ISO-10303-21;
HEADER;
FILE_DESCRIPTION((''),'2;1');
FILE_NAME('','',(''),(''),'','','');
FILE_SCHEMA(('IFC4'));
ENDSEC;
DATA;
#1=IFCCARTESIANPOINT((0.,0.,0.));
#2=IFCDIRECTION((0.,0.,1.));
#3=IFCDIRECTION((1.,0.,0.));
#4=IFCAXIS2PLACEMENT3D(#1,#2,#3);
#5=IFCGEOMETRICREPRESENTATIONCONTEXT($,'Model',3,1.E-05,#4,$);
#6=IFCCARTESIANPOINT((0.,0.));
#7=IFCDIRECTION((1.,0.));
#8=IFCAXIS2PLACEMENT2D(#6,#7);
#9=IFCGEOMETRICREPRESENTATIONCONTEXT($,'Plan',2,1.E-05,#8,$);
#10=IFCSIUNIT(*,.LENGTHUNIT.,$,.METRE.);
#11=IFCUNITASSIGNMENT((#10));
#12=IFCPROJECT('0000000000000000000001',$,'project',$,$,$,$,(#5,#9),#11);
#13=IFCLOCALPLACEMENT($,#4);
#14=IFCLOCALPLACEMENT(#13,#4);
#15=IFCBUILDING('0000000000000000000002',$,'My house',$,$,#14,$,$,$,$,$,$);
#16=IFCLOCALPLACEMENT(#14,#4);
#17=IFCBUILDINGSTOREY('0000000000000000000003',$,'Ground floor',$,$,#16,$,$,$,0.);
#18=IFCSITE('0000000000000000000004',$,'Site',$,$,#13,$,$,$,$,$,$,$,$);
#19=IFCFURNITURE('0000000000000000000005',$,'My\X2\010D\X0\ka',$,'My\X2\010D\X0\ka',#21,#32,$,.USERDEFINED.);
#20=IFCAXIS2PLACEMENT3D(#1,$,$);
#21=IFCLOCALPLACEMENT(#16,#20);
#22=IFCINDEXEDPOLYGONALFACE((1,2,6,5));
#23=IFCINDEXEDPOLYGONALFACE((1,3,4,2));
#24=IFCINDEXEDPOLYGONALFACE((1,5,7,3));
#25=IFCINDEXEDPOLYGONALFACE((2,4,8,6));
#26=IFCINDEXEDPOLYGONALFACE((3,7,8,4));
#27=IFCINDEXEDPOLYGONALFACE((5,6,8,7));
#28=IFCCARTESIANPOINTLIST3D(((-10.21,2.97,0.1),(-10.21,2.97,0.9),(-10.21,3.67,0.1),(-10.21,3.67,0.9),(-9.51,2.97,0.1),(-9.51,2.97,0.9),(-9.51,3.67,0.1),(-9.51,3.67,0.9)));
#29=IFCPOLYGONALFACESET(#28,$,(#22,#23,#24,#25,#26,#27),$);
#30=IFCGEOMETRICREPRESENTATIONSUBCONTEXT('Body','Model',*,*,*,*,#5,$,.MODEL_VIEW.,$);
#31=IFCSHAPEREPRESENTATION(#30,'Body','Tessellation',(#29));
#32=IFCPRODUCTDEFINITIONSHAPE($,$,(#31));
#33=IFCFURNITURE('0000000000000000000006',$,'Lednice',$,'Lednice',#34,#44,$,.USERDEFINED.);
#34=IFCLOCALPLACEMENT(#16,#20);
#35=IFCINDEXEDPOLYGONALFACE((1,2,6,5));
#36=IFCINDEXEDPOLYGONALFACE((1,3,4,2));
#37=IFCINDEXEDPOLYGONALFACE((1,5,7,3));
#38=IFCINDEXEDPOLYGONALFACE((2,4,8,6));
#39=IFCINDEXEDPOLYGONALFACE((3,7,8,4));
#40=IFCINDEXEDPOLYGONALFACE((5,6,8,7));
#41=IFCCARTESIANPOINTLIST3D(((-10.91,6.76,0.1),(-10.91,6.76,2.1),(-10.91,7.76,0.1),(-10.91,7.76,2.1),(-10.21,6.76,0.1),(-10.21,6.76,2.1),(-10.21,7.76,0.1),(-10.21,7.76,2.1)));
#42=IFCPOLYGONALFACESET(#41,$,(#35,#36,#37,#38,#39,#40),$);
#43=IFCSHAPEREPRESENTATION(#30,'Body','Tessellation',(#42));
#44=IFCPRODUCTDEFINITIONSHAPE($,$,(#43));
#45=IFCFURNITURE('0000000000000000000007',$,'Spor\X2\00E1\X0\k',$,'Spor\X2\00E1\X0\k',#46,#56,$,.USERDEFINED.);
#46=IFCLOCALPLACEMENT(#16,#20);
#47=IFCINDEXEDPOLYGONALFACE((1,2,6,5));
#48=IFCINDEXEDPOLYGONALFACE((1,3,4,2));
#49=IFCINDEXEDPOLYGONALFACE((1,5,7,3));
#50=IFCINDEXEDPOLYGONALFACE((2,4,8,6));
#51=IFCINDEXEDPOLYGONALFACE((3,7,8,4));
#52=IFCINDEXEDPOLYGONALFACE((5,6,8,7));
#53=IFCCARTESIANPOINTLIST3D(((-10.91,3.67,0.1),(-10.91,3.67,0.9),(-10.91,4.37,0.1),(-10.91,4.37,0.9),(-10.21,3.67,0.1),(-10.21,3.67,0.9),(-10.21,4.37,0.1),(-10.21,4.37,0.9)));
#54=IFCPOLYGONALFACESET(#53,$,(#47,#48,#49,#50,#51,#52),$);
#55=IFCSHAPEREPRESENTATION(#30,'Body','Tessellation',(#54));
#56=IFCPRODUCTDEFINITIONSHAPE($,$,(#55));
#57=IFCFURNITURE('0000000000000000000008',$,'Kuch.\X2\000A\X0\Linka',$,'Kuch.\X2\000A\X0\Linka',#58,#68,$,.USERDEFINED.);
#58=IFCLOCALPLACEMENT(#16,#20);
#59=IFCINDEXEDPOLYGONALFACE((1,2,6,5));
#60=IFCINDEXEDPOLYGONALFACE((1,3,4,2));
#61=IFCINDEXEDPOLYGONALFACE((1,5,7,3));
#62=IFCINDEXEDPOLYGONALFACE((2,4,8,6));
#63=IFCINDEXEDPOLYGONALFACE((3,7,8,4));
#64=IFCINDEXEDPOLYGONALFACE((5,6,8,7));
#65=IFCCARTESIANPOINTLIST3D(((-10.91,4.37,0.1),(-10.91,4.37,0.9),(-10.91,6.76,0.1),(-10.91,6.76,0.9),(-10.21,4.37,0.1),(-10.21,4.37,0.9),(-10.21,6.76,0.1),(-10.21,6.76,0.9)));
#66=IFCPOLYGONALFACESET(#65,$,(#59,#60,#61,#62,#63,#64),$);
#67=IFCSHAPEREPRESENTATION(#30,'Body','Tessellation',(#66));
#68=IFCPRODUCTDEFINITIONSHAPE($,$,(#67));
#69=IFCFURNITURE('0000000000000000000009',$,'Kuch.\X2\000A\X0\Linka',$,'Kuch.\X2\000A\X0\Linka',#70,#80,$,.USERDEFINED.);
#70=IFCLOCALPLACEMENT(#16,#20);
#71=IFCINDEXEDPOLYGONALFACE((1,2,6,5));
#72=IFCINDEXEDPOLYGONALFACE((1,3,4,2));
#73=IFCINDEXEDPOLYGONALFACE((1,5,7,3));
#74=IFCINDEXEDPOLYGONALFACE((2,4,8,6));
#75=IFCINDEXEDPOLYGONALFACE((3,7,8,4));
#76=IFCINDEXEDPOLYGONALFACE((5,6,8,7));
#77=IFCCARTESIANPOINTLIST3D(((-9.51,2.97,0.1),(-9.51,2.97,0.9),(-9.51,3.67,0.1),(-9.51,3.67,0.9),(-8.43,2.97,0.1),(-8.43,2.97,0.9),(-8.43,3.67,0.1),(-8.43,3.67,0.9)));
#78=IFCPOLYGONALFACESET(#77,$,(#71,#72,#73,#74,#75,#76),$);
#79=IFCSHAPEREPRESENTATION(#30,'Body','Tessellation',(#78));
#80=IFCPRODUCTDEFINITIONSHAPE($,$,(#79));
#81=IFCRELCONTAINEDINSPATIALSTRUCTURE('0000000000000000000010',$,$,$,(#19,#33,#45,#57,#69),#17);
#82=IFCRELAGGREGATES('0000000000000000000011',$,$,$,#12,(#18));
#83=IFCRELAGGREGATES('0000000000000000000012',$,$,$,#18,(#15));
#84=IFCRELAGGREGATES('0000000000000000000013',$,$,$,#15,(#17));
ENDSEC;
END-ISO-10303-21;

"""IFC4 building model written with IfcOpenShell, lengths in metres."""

from ifc_helpers import new_model, entity, si_unit, frame, origin_with_axes, origin_2d_with_axis, place, context, subcontext, project, spatial, indexed_curve, outline, extrude, shape, source, transform, mapped, element, save


model = new_model("IFC4")

# Units and contexts
model_context = context("Model", 3, precision=1e-05, world=origin_with_axes())
plan_context = context("Plan", 2, precision=1e-05, world=origin_2d_with_axis())
body_context_1 = subcontext(model_context, "Body", "Model", "MODEL_VIEW")
body_context_2 = subcontext(plan_context, "Body", "Plan", "PLAN_VIEW")
ifc_project = project(units=[si_unit("LENGTHUNIT", "METRE")], contexts=[model_context, plan_context])

# Site, building, storey
site_placement = place(None, origin_with_axes())
site = spatial("IfcSite", under=ifc_project, at=site_placement, Name="Site")
building_placement = place(site_placement, origin_with_axes())
building = spatial("IfcBuilding", under=site, at=building_placement, Name="My house")
storey_placement = place(building_placement, origin_with_axes())
storey = spatial("IfcBuildingStorey", under=building, at=storey_placement, Name="Ground floor", Elevation=0.0)

# Furniture
shared_shape_1 = source(origin_with_axes(), body_context_1, "Body", "SweptSolid", [
    extrude(outline(indexed_curve([(-0.35, -0.35), (0.35, -0.35), (0.35, 0.35), (-0.35, 0.35)])), None, (0.0, 0.0, 1.0), 0.8),
])
shared_shape_2 = source(origin_with_axes(), body_context_2, "Body", "Curve2D", [
    entity("IfcIndexedPolyCurve", entity("IfcCartesianPointList2D", [[-0.35, -0.35], [0.35, -0.35], [0.35, 0.35], [-0.35, 0.35], [-0.35, -0.35]]), None, False),
])
furniture_1_placement = place(storey_placement, frame((-9.86, 3.32, 0.1), z_axis=(0.0, 0.0, 1.0), x_axis=(1.0, 0.0, 0.0)))
element("IfcFurniture", 1, at=furniture_1_placement, inside=storey, Name="Myčka", ObjectType="Myčka", PredefinedType="USERDEFINED", shapes=[
    shape(body_context_1, "Body", "MappedRepresentation", [mapped(shared_shape_1, transform((0.0, 0.0, 0.0), x_axis=(-1.0, 0.0, 0.0), y_axis=(0.0, 1.0, 0.0), z_axis=(0.0, 0.0, 1.0), scale=1.0))]),
    shape(body_context_2, "Body", "MappedRepresentation", [mapped(shared_shape_2, transform((0.0, 0.0, 0.0), x_axis=(-1.0, 0.0, 0.0), y_axis=(0.0, 1.0, 0.0), z_axis=(0.0, 0.0, 1.0), scale=1.0))]),
])
shared_shape_3 = source(origin_with_axes(), body_context_1, "Body", "SweptSolid", [
    extrude(outline(indexed_curve([(-0.35, -0.5), (0.35, -0.5), (0.35, 0.5), (-0.35, 0.5)])), None, (0.0, 0.0, 1.0), 2.0),
])
shared_shape_4 = source(origin_with_axes(), body_context_2, "Body", "Curve2D", [
    entity("IfcIndexedPolyCurve", entity("IfcCartesianPointList2D", [[-0.35, -0.5], [0.35, -0.5], [0.35, 0.5], [-0.35, 0.5], [-0.35, -0.5]]), None, False),
])
furniture_2_placement = place(storey_placement, frame((-10.56, 7.26, 0.1), z_axis=(0.0, 0.0, 1.0), x_axis=(1.0, 0.0, 0.0)))
element("IfcFurniture", 2, at=furniture_2_placement, inside=storey, Name="Lednice", ObjectType="Lednice", PredefinedType="USERDEFINED", shapes=[
    shape(body_context_1, "Body", "MappedRepresentation", [mapped(shared_shape_3, transform((0.0, 0.0, 0.0), x_axis=(-1.0, 0.0, 0.0), y_axis=(0.0, 1.0, 0.0), z_axis=(0.0, 0.0, 1.0), scale=1.0))]),
    shape(body_context_2, "Body", "MappedRepresentation", [mapped(shared_shape_4, transform((0.0, 0.0, 0.0), x_axis=(-1.0, 0.0, 0.0), y_axis=(0.0, 1.0, 0.0), z_axis=(0.0, 0.0, 1.0), scale=1.0))]),
])
shared_shape_5 = source(origin_with_axes(), body_context_1, "Body", "SweptSolid", [
    extrude(outline(indexed_curve([(-0.35, -0.35), (0.35, -0.35), (0.35, 0.35), (-0.35, 0.35)])), None, (0.0, 0.0, 1.0), 0.8),
])
shared_shape_6 = source(origin_with_axes(), body_context_2, "Body", "Curve2D", [
    entity("IfcIndexedPolyCurve", entity("IfcCartesianPointList2D", [[-0.35, -0.35], [0.35, -0.35], [0.35, 0.35], [-0.35, 0.35], [-0.35, -0.35]]), None, False),
])
furniture_3_placement = place(storey_placement, frame((-10.56, 4.02, 0.1), z_axis=(0.0, 0.0, 1.0), x_axis=(1.0, 0.0, 0.0)))
element("IfcFurniture", 3, at=furniture_3_placement, inside=storey, Name="Sporák", ObjectType="Sporák", PredefinedType="USERDEFINED", shapes=[
    shape(body_context_1, "Body", "MappedRepresentation", [mapped(shared_shape_5, transform((0.0, 0.0, 0.0), x_axis=(-1.0, 0.0, 0.0), y_axis=(0.0, 1.0, 0.0), z_axis=(0.0, 0.0, 1.0), scale=1.0))]),
    shape(body_context_2, "Body", "MappedRepresentation", [mapped(shared_shape_6, transform((0.0, 0.0, 0.0), x_axis=(-1.0, 0.0, 0.0), y_axis=(0.0, 1.0, 0.0), z_axis=(0.0, 0.0, 1.0), scale=1.0))]),
])
shared_shape_7 = source(origin_with_axes(), body_context_1, "Body", "SweptSolid", [
    extrude(outline(indexed_curve([(-0.35, -1.195), (0.35, -1.195), (0.35, 1.195), (-0.35, 1.195)])), None, (0.0, 0.0, 1.0), 0.8),
])
shared_shape_8 = source(origin_with_axes(), body_context_2, "Body", "Curve2D", [
    entity("IfcIndexedPolyCurve", entity("IfcCartesianPointList2D", [[-0.35, -1.195], [0.35, -1.195], [0.35, 1.195], [-0.35, 1.195], [-0.35, -1.195]]), None, False),
])
furniture_4_placement = place(storey_placement, frame((-10.56, 5.565, 0.1), z_axis=(0.0, 0.0, 1.0), x_axis=(1.0, 0.0, 0.0)))
element("IfcFurniture", 4, at=furniture_4_placement, inside=storey, Name="Kuch.\nLinka", ObjectType="Kuch.\nLinka", PredefinedType="USERDEFINED", shapes=[
    shape(body_context_1, "Body", "MappedRepresentation", [mapped(shared_shape_7, transform((0.0, 0.0, 0.0), x_axis=(-1.0, 0.0, 0.0), y_axis=(0.0, 1.0, 0.0), z_axis=(0.0, 0.0, 1.0), scale=1.0))]),
    shape(body_context_2, "Body", "MappedRepresentation", [mapped(shared_shape_8, transform((0.0, 0.0, 0.0), x_axis=(-1.0, 0.0, 0.0), y_axis=(0.0, 1.0, 0.0), z_axis=(0.0, 0.0, 1.0), scale=1.0))]),
])
shared_shape_9 = source(origin_with_axes(), body_context_1, "Body", "SweptSolid", [
    extrude(outline(indexed_curve([(-0.54, -0.35), (0.54, -0.35), (0.54, 0.35), (-0.54, 0.35)])), None, (0.0, 0.0, 1.0), 0.8),
])
shared_shape_10 = source(origin_with_axes(), body_context_2, "Body", "Curve2D", [
    entity("IfcIndexedPolyCurve", entity("IfcCartesianPointList2D", [[-0.54, -0.35], [0.54, -0.35], [0.54, 0.35], [-0.54, 0.35], [-0.54, -0.35]]), None, False),
])
furniture_5_placement = place(storey_placement, frame((-8.97, 3.32, 0.1), z_axis=(0.0, 0.0, 1.0), x_axis=(1.0, 0.0, 0.0)))
element("IfcFurniture", 5, at=furniture_5_placement, inside=storey, Name="Kuch.\nLinka", ObjectType="Kuch.\nLinka", PredefinedType="USERDEFINED", shapes=[
    shape(body_context_1, "Body", "MappedRepresentation", [mapped(shared_shape_9, transform((0.0, 0.0, 0.0), x_axis=(-1.0, 0.0, 0.0), y_axis=(0.0, 1.0, 0.0), z_axis=(0.0, 0.0, 1.0), scale=1.0))]),
    shape(body_context_2, "Body", "MappedRepresentation", [mapped(shared_shape_10, transform((0.0, 0.0, 0.0), x_axis=(-1.0, 0.0, 0.0), y_axis=(0.0, 1.0, 0.0), z_axis=(0.0, 0.0, 1.0), scale=1.0))]),
])

save(model, "model.ifc")
